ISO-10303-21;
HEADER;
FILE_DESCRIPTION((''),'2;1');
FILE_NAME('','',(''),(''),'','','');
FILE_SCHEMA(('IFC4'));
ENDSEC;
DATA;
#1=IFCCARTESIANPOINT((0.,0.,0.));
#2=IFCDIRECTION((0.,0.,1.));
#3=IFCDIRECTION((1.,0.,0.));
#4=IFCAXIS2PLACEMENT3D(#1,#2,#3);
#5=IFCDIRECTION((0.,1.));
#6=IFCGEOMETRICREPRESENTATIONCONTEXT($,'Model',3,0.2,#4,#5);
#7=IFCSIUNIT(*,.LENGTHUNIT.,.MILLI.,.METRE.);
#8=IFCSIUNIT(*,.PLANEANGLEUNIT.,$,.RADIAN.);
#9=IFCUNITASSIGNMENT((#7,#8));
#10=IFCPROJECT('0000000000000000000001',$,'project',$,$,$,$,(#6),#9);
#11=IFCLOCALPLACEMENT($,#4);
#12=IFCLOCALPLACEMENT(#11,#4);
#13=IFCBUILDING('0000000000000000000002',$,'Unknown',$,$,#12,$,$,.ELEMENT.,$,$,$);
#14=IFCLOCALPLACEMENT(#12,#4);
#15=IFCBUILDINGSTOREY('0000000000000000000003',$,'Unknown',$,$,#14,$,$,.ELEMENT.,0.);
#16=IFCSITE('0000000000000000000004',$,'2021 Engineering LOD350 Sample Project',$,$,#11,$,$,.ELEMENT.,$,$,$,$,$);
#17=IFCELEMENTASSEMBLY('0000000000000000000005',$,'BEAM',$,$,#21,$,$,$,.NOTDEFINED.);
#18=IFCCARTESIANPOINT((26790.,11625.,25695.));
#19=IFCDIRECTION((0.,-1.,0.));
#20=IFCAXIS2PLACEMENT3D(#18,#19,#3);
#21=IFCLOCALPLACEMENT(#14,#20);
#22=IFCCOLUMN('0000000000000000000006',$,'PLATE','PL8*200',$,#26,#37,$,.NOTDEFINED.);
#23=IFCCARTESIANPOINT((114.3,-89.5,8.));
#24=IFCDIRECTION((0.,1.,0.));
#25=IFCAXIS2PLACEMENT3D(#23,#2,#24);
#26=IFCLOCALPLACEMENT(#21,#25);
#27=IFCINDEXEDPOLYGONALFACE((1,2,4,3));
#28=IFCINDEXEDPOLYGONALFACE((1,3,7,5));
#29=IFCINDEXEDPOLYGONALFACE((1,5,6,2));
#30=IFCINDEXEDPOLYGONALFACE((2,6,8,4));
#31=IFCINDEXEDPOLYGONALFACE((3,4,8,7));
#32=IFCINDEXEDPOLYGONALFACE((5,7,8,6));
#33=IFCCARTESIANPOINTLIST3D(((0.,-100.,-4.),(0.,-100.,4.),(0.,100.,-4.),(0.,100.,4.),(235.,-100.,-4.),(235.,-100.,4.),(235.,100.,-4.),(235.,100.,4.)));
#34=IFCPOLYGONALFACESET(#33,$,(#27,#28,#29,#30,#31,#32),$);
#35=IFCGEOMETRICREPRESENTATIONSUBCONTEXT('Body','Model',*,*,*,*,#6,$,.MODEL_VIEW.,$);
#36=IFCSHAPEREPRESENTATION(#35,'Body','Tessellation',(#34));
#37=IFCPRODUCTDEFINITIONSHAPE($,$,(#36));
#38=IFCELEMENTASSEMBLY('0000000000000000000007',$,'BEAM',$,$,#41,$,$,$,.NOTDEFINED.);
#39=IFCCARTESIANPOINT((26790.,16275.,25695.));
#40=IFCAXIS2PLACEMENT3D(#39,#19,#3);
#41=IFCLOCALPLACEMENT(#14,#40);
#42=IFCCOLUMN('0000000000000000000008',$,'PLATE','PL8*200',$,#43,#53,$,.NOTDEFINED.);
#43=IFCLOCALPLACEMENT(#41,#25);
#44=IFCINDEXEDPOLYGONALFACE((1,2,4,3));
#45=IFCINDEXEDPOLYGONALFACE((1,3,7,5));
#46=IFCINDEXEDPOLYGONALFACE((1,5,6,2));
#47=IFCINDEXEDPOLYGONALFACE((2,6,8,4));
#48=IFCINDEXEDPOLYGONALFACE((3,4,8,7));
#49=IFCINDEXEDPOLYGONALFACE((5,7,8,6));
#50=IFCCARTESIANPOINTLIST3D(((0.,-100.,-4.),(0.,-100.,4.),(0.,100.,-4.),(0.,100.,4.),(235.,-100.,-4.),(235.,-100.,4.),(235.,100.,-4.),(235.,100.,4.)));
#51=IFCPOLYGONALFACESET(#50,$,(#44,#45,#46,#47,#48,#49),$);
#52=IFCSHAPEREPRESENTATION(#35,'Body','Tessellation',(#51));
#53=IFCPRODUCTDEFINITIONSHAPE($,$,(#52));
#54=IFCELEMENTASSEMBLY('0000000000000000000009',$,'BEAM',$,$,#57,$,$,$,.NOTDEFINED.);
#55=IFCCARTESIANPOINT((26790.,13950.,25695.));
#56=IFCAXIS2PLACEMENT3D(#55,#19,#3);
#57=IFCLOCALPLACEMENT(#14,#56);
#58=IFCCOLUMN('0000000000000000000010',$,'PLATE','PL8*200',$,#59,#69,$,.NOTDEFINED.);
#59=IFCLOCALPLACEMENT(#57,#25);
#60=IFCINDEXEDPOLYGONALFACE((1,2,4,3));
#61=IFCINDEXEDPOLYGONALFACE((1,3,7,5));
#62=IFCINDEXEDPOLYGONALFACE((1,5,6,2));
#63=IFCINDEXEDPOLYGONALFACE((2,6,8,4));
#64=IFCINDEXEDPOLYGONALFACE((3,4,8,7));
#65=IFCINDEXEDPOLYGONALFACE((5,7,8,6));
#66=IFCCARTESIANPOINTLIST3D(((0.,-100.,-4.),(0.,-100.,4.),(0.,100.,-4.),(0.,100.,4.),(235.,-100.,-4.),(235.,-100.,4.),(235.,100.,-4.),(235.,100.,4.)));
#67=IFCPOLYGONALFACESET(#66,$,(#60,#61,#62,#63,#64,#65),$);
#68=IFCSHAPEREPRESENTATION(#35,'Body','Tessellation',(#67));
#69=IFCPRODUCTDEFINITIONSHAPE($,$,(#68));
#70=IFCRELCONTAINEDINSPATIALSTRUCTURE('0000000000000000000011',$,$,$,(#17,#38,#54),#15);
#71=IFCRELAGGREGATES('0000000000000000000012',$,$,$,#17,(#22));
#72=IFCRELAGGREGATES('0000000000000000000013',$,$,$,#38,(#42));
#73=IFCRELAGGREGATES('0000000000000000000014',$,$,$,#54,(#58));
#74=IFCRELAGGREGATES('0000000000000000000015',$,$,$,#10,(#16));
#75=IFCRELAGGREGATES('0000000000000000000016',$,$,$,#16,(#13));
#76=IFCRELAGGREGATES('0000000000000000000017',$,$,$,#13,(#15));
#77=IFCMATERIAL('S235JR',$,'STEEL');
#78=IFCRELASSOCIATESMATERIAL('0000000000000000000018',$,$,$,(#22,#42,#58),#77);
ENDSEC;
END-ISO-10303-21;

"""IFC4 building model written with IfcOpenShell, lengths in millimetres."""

from ifc_helpers import new_model, si_unit, direction, frame, origin_with_axes, place, context, subcontext, project, spatial, line, indexed_curve, outline, extrude, material, element, aggregate, save


model = new_model("IFC4")

# Units and contexts
model_context = context("Model", 3, precision=0.2, world=origin_with_axes(), true_north=direction((0.0, 1.0)))
body_context = subcontext(model_context, "Body", "Model", "MODEL_VIEW")
ifc_project = project(units=[si_unit("LENGTHUNIT", "METRE", prefix="MILLI"), si_unit("PLANEANGLEUNIT", "RADIAN")], contexts=[model_context])

# Site, building, storey
site_placement = place(None, origin_with_axes())
site = spatial("IfcSite", under=ifc_project, at=site_placement, Name="2021 Engineering LOD350 Sample Project", CompositionType="ELEMENT")
building_placement = place(site_placement, origin_with_axes())
building = spatial("IfcBuilding", under=site, at=building_placement, Name="Unknown", CompositionType="ELEMENT")
storey_placement = place(building_placement, origin_with_axes())
storey = spatial("IfcBuildingStorey", under=building, at=storey_placement, Name="Unknown", CompositionType="ELEMENT", Elevation=0.0)

# Element assemblies, columns
assembly_1_placement = place(storey_placement, frame((26790.0, 11625.0, 25695.0), z_axis=(0.0, -1.0, 0.0), x_axis=(1.0, 0.0, 0.0)))
assembly_1 = element("IfcElementAssembly", 1, at=assembly_1_placement, inside=storey, Name="BEAM", PredefinedType="NOTDEFINED")
ifc_material_1 = material(Name="S235JR", Category="STEEL")
column_1_placement = place(assembly_1_placement, frame((114.3, -89.5, 8.0), z_axis=(0.0, 0.0, 1.0), x_axis=(0.0, 1.0, 0.0)))
column_1 = element("IfcColumn", 2, at=column_1_placement, material=ifc_material_1, Name="PLATE", Description="PL8*200", PredefinedType="NOTDEFINED", context=body_context, shape_type="SolidModel", body=[
    extrude(outline(indexed_curve([(-4.0, -100.0), (4.0, -100.0), (4.0, 100.0), (-4.0, 100.0)], segments=[line(1, 2, 3, 4, 1)])), frame((0.0, 0.0, 0.0), z_axis=(-1.0, 0.0, 0.0), x_axis=(0.0, 0.0, 1.0)), (0.0, 0.0, -1.0), 235.0),
])
assembly_2_placement = place(storey_placement, frame((26790.0, 16275.0, 25695.0), z_axis=(0.0, -1.0, 0.0), x_axis=(1.0, 0.0, 0.0)))
assembly_2 = element("IfcElementAssembly", 3, at=assembly_2_placement, inside=storey, Name="BEAM", PredefinedType="NOTDEFINED")
column_2_placement = place(assembly_2_placement, frame((114.3, -89.5, 8.0), z_axis=(0.0, 0.0, 1.0), x_axis=(0.0, 1.0, 0.0)))
column_2 = element("IfcColumn", 4, at=column_2_placement, material=ifc_material_1, Name="PLATE", Description="PL8*200", PredefinedType="NOTDEFINED", context=body_context, shape_type="SolidModel", body=[
    extrude(outline(indexed_curve([(-4.0, -100.0), (4.0, -100.0), (4.0, 100.0), (-4.0, 100.0)], segments=[line(1, 2, 3, 4, 1)])), frame((0.0, 0.0, 0.0), z_axis=(-1.0, 0.0, 0.0), x_axis=(0.0, 0.0, 1.0)), (0.0, 0.0, -1.0), 235.0),
])
assembly_3_placement = place(storey_placement, frame((26790.0, 13950.0, 25695.0), z_axis=(0.0, -1.0, 0.0), x_axis=(1.0, 0.0, 0.0)))
assembly_3 = element("IfcElementAssembly", 5, at=assembly_3_placement, inside=storey, Name="BEAM", PredefinedType="NOTDEFINED")
column_3_placement = place(assembly_3_placement, frame((114.3, -89.5, 8.0), z_axis=(0.0, 0.0, 1.0), x_axis=(0.0, 1.0, 0.0)))
column_3 = element("IfcColumn", 6, at=column_3_placement, material=ifc_material_1, Name="PLATE", Description="PL8*200", PredefinedType="NOTDEFINED", context=body_context, shape_type="SolidModel", body=[
    extrude(outline(indexed_curve([(-4.0, -100.0), (4.0, -100.0), (4.0, 100.0), (-4.0, 100.0)], segments=[line(1, 2, 3, 4, 1)])), frame((0.0, 0.0, 0.0), z_axis=(-1.0, 0.0, 0.0), x_axis=(0.0, 0.0, 1.0)), (0.0, 0.0, -1.0), 235.0),
])

aggregate(assembly_1, [column_1])
aggregate(assembly_2, [column_2])
aggregate(assembly_3, [column_3])

save(model, "model.ifc")
